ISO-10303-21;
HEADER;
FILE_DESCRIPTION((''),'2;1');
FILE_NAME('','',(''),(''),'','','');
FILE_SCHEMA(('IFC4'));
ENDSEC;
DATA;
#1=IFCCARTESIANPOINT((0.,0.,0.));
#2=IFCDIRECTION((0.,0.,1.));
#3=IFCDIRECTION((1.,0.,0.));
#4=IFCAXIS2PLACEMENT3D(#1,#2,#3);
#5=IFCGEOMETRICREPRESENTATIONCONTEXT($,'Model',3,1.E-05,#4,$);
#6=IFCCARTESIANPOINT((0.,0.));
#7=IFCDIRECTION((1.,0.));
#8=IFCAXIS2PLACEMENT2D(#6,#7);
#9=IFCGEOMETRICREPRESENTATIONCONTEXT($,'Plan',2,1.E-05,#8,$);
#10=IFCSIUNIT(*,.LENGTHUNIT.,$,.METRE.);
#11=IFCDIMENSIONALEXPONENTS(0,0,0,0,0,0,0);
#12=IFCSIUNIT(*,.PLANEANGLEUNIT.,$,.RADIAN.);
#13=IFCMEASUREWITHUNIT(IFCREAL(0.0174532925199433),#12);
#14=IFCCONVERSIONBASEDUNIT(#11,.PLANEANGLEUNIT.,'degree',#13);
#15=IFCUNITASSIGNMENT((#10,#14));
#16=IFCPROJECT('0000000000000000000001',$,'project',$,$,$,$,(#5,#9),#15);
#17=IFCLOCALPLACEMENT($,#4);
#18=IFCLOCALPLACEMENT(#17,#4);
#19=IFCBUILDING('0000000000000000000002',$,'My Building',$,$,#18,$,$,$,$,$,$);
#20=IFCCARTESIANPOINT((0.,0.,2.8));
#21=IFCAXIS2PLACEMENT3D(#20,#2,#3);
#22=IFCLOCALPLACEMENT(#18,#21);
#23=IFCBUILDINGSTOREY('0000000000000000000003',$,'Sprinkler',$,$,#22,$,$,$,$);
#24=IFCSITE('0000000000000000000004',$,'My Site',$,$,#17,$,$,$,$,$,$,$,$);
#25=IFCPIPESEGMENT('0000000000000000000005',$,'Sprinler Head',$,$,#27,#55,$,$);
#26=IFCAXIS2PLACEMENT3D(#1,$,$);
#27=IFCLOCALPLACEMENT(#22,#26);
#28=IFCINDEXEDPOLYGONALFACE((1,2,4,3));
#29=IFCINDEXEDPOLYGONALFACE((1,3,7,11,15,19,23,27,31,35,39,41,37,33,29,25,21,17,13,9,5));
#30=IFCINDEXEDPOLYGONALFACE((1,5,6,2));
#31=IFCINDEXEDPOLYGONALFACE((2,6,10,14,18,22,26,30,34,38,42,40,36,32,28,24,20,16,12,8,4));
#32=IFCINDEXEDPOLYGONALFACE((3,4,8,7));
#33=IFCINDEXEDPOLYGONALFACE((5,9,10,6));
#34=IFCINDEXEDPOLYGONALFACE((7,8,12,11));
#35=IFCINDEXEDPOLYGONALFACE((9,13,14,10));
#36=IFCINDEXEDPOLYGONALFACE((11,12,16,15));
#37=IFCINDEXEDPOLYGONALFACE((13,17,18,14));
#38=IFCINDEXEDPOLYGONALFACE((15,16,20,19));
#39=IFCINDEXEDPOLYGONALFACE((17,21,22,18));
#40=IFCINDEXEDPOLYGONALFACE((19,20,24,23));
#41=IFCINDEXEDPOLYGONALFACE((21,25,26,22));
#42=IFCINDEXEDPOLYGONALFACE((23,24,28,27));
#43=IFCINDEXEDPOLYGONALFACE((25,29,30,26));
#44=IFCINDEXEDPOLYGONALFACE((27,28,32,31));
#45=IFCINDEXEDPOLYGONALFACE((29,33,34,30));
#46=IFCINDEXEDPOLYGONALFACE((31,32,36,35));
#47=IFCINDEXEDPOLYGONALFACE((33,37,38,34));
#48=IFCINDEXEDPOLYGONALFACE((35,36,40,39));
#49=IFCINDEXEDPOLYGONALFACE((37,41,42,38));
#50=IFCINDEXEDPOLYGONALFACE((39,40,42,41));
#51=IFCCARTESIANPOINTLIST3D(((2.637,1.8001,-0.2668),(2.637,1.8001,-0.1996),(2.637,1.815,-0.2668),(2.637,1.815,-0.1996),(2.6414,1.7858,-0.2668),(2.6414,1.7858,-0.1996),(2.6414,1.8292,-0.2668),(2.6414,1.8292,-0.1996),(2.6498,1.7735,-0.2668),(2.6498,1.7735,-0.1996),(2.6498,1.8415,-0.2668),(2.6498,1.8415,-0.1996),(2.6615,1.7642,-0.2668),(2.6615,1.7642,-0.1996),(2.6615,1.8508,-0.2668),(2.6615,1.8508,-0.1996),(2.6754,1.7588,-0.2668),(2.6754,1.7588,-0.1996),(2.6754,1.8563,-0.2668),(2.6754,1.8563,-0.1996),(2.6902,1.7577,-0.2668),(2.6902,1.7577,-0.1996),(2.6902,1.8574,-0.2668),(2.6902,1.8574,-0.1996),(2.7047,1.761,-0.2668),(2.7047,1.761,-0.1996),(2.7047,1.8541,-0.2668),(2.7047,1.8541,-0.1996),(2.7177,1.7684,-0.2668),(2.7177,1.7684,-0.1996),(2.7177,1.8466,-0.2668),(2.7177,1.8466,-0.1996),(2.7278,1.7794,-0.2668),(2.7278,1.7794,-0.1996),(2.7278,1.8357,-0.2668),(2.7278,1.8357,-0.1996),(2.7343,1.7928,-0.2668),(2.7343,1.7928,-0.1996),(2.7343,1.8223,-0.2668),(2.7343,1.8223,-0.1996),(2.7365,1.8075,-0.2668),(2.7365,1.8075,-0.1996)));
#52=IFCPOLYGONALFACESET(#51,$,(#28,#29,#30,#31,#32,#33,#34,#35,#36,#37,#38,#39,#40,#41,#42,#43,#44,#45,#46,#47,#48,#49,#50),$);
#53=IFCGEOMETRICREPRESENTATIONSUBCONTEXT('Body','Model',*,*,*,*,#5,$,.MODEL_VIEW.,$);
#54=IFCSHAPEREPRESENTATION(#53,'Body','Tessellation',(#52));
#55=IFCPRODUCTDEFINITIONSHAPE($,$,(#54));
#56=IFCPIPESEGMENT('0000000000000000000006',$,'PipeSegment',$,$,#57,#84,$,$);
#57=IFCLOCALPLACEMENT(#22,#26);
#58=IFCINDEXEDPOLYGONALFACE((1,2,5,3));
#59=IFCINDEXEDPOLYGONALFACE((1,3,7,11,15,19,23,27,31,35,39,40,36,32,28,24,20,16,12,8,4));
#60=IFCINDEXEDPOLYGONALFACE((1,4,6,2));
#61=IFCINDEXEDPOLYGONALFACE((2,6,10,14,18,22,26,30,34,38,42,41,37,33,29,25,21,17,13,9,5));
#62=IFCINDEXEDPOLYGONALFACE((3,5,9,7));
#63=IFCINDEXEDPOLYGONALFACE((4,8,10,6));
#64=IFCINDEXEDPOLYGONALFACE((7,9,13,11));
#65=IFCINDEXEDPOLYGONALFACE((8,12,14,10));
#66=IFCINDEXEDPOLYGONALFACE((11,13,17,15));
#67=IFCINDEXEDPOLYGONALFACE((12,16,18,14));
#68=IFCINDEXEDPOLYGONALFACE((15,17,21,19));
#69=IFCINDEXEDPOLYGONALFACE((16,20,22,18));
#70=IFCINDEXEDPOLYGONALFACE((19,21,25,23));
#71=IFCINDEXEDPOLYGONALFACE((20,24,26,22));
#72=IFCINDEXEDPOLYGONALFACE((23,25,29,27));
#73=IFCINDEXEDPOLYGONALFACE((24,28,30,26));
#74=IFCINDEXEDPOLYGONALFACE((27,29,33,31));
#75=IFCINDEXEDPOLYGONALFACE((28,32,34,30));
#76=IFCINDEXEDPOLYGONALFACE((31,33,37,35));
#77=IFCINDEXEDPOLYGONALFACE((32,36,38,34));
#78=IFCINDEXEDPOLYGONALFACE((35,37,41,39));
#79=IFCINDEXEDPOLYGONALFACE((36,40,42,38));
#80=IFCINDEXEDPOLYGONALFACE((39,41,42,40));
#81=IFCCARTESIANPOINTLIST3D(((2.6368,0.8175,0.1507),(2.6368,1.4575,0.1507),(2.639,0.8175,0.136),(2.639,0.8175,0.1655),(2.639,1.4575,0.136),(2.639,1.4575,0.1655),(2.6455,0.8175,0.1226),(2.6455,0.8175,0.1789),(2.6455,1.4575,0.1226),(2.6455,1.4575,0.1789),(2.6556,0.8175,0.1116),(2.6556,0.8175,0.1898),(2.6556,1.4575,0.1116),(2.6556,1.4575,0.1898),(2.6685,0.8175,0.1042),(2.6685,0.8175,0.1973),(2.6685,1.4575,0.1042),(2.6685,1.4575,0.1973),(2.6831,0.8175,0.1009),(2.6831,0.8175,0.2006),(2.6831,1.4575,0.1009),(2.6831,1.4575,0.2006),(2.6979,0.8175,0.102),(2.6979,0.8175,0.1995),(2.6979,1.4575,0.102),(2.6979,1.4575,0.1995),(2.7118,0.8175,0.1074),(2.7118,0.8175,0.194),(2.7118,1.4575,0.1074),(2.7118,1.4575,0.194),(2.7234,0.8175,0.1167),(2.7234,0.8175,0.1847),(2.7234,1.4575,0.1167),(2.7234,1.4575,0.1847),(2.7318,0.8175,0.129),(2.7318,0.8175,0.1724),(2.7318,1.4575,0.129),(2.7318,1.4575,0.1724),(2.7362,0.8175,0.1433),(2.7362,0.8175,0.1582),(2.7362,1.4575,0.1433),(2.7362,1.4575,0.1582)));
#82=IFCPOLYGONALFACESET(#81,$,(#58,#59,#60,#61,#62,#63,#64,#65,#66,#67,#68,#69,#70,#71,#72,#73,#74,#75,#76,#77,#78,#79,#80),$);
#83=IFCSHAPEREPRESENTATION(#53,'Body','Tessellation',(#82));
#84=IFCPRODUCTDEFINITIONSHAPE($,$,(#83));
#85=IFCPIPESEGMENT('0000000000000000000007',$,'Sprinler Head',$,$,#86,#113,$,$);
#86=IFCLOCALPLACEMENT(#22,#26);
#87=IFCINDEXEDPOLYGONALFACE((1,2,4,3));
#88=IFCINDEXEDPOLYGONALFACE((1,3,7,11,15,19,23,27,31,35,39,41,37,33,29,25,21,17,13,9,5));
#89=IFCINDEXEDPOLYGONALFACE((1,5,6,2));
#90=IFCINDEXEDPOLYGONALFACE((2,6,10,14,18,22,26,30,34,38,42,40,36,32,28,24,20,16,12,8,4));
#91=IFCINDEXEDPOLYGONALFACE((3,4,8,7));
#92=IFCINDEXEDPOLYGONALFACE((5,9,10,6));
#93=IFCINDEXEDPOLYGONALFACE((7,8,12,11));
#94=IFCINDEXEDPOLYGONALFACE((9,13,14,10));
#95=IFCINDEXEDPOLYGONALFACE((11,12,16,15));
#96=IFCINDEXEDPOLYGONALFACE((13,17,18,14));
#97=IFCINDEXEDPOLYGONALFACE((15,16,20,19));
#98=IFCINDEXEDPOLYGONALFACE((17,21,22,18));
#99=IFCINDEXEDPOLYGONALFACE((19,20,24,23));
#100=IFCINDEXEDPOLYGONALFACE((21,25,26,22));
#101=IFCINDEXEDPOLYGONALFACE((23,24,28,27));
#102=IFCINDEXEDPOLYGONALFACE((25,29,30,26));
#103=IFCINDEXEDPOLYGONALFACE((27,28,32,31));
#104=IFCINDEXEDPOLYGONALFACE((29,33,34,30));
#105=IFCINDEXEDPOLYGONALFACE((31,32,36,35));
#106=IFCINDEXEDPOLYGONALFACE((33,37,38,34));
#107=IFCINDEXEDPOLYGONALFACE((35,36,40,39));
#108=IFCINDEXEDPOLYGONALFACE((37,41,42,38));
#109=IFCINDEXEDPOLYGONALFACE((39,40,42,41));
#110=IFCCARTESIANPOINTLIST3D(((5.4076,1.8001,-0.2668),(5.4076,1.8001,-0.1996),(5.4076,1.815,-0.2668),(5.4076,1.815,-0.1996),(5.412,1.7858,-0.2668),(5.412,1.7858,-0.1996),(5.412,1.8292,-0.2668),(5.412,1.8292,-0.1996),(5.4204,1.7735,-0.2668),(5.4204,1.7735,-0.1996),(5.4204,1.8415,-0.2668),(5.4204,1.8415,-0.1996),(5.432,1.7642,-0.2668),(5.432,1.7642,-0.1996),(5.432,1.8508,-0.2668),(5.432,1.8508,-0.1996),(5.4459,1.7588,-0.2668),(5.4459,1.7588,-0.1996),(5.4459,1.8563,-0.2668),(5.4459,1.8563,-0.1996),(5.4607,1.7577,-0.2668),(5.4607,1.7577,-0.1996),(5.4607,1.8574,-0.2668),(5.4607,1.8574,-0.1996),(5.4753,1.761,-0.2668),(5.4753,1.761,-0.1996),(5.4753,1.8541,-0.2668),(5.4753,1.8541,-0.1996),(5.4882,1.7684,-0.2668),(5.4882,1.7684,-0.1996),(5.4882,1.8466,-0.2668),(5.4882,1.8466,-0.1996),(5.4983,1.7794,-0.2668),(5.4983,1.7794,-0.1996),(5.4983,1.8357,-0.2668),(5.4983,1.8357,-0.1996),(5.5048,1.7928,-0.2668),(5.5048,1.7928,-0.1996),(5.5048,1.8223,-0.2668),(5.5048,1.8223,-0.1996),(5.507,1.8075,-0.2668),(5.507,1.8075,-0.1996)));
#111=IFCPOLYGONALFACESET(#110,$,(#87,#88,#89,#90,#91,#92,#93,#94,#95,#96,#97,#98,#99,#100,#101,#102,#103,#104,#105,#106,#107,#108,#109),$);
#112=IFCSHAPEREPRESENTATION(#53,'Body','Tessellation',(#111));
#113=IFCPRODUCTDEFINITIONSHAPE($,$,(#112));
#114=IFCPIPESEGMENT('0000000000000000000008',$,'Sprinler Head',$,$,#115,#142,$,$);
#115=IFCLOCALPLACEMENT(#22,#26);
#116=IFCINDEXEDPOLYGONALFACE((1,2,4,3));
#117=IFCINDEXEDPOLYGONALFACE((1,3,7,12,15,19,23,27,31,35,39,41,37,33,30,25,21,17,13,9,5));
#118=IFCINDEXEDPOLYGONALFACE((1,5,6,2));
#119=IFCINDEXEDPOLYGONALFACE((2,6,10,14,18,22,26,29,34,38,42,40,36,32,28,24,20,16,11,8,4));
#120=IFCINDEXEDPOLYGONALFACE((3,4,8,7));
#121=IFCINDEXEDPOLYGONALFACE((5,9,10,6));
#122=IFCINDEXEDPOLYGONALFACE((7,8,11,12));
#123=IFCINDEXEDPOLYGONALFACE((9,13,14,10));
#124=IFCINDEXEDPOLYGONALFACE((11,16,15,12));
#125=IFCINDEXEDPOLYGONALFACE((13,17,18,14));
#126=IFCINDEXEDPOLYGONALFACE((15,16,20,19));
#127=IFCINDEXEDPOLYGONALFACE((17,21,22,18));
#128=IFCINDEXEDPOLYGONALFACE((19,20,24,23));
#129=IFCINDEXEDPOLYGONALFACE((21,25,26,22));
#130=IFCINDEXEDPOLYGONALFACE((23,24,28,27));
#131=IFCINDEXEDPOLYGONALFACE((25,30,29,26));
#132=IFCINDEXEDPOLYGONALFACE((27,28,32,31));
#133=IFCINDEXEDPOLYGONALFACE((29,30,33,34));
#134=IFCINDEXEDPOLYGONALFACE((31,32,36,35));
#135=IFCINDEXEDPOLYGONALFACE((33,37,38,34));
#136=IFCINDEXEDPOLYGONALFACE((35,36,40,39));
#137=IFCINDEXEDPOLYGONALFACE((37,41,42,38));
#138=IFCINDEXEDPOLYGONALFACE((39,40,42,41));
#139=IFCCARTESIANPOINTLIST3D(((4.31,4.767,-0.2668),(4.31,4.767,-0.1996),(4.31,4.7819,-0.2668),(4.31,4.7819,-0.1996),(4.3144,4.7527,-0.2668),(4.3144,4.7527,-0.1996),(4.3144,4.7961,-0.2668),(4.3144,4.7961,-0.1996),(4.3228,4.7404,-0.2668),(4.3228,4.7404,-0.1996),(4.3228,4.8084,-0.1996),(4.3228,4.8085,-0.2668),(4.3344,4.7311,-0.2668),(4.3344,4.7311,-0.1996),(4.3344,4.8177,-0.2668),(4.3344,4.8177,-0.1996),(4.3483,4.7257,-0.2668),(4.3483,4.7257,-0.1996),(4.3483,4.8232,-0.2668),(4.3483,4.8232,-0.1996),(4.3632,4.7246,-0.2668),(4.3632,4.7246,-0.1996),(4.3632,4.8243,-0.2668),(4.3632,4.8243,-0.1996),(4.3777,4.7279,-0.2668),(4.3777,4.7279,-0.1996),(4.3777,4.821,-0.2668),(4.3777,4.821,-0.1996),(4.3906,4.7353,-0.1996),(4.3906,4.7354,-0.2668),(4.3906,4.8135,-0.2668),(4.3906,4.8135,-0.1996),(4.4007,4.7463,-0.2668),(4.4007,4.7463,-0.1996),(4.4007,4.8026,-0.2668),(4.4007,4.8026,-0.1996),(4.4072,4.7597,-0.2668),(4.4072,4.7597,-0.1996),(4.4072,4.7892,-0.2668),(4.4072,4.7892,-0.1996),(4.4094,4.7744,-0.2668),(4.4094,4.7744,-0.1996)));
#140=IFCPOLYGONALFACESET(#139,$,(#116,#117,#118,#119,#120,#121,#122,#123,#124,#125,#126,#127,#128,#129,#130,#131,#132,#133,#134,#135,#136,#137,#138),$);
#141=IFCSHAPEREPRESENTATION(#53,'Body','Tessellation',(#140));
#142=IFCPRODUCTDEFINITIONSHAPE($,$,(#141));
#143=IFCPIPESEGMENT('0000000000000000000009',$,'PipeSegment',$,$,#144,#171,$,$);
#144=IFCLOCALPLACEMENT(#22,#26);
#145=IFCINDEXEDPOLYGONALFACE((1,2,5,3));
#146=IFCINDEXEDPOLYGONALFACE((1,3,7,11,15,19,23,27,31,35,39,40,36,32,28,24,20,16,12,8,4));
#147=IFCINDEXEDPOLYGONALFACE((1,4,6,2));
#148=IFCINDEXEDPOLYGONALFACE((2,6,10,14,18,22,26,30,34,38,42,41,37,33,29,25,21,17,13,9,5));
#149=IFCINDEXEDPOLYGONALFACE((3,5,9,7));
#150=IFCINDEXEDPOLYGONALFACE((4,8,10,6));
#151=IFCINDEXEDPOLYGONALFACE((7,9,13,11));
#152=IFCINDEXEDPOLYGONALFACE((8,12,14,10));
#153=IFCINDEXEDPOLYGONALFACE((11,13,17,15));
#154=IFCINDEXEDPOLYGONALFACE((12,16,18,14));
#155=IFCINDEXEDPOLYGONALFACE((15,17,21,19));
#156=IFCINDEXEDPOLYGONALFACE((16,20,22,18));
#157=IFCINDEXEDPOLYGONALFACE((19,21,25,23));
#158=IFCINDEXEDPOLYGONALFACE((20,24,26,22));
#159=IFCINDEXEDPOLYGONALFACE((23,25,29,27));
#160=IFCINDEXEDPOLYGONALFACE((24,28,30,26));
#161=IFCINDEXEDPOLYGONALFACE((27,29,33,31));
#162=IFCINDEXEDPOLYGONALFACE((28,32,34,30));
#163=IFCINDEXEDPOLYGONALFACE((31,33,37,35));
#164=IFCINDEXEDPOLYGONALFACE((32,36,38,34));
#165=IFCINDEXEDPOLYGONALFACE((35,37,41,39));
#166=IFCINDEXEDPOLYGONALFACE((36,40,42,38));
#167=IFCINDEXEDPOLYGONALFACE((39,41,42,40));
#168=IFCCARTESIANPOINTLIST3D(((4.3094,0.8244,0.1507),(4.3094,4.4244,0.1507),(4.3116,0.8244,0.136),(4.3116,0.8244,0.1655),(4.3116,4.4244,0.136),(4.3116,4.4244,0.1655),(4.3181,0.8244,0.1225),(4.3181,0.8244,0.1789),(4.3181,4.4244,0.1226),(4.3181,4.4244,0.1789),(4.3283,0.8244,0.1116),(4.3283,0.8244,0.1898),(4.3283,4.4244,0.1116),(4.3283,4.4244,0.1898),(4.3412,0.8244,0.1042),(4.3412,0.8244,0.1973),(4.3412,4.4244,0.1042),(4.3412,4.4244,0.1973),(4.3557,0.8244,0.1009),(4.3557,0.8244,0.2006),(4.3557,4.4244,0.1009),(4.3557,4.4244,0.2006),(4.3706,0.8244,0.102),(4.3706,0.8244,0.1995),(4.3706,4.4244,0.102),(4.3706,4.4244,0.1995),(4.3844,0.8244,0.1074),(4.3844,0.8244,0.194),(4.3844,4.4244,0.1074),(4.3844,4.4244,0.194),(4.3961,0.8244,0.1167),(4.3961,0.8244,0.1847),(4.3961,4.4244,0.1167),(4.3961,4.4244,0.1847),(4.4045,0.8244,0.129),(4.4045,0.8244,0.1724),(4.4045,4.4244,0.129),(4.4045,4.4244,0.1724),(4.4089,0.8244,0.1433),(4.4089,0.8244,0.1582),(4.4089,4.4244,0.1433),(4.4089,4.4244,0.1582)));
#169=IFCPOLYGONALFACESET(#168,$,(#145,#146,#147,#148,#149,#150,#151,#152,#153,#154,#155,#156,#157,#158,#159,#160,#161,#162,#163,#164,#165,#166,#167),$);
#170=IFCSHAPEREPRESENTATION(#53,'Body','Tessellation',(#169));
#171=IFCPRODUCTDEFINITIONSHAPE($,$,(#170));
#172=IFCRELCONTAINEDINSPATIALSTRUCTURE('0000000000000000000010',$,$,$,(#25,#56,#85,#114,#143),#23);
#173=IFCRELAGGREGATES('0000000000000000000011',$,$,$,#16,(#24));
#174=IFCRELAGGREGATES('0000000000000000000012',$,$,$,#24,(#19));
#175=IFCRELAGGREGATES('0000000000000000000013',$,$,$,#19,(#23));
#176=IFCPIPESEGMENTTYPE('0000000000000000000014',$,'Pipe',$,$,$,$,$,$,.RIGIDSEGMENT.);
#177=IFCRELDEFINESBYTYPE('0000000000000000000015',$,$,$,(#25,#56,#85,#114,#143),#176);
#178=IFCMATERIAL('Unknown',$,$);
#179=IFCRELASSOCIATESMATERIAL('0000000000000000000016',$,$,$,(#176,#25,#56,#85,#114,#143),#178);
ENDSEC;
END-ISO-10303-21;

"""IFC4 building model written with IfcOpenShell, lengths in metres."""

from ifc_helpers import new_model, entity, si_unit, converted_unit, frame, origin_with_axes, origin_2d_with_axis, place, context, subcontext, project, spatial, circle, extrude, material, material_profile, profile_set, profile_usage, type_object, element, save


model = new_model("IFC4")

# Units and contexts
model_context = context("Model", 3, precision=1e-05, world=origin_with_axes())
plan_context = context("Plan", 2, precision=1e-05, world=origin_2d_with_axis())
body_context = subcontext(model_context, "Body", "Model", "MODEL_VIEW")
ifc_project = project(units=[si_unit("LENGTHUNIT", "METRE"), converted_unit("PLANEANGLEUNIT", "degree", entity("IfcReal", 0.0174532925199433), si_unit("PLANEANGLEUNIT", "RADIAN"), dimensions=[0, 0, 0, 0, 0, 0, 0])], contexts=[model_context, plan_context])

# Site, building, storey
site_placement = place(None, origin_with_axes())
site = spatial("IfcSite", under=ifc_project, at=site_placement, Name="My Site")
building_placement = place(site_placement, origin_with_axes())
building = spatial("IfcBuilding", under=site, at=building_placement, Name="My Building")
storey_placement = place(building_placement, frame((0.0, 0.0, 2.8), z_axis=(0.0, 0.0, 1.0), x_axis=(1.0, 0.0, 0.0)))
storey = spatial("IfcBuildingStorey", under=building, at=storey_placement, Name="Sprinkler")

# Pipe segments
ifc_material = material(Name="Unknown")
ifc_material_profile_1 = material_profile(ifc_material, circle(Radius=0.05))
ifc_profile_set_1 = profile_set([ifc_material_profile_1])
pipe_segment_type = type_object("IfcPipeSegmentType", Name="Pipe", PredefinedType="RIGIDSEGMENT", material=ifc_profile_set_1)
ifc_profile_usage_1 = profile_usage(ifc_profile_set_1, cardinal=5)
pipe_segment_1_placement = place(storey_placement, frame((2.6865, 1.8075, -0.2668), z_axis=(0.0, -0.000008, 1.0), x_axis=(1.0, 0.0, 0.0)))
element("IfcPipeSegment", 1, at=pipe_segment_1_placement, inside=storey, type_object=pipe_segment_type, material=ifc_profile_usage_1, Name="Sprinler Head", context=body_context, shape_type="SweptSolid", body=[
    extrude(circle(Radius=0.05), origin_with_axes(), (0.0, 0.0, 1.0), 0.0672),
])
ifc_profile_usage_2 = profile_usage(ifc_profile_set_1, cardinal=5)
pipe_segment_2_placement = place(storey_placement, frame((2.6868, 0.8175, 0.1507), z_axis=(0.0, 1.0, 0.0), x_axis=(-1.0, 0.0, 0.0)))
element("IfcPipeSegment", 2, at=pipe_segment_2_placement, inside=storey, type_object=pipe_segment_type, material=ifc_profile_usage_2, Name="PipeSegment", context=body_context, shape_type="SweptSolid", body=[
    extrude(circle(Radius=0.05), origin_with_axes(), (0.0, 0.0, 1.0), 0.64),
])
ifc_profile_usage_3 = profile_usage(ifc_profile_set_1, cardinal=5)
pipe_segment_3_placement = place(storey_placement, frame((5.457, 1.8075, -0.2668), z_axis=(0.0, -0.000008, 1.0), x_axis=(1.0, 0.0, 0.0)))
element("IfcPipeSegment", 3, at=pipe_segment_3_placement, inside=storey, type_object=pipe_segment_type, material=ifc_profile_usage_3, Name="Sprinler Head", context=body_context, shape_type="SweptSolid", body=[
    extrude(circle(Radius=0.05), origin_with_axes(), (0.0, 0.0, 1.0), 0.0672),
])
ifc_profile_usage_4 = profile_usage(ifc_profile_set_1, cardinal=5)
pipe_segment_4_placement = place(storey_placement, frame((4.3594, 4.7744, -0.2668), z_axis=(0.0, -0.000008, 1.0), x_axis=(1.0, 0.0, 0.0)))
element("IfcPipeSegment", 4, at=pipe_segment_4_placement, inside=storey, type_object=pipe_segment_type, material=ifc_profile_usage_4, Name="Sprinler Head", context=body_context, shape_type="SweptSolid", body=[
    extrude(circle(Radius=0.05), origin_with_axes(), (0.0, 0.0, 1.0), 0.0672),
])
ifc_profile_usage_5 = profile_usage(ifc_profile_set_1, cardinal=5)
pipe_segment_5_placement = place(storey_placement, frame((4.3594, 0.8244, 0.1507), z_axis=(0.0, 1.0, 0.000004), x_axis=(-1.0, 0.0, 0.0)))
element("IfcPipeSegment", 5, at=pipe_segment_5_placement, inside=storey, type_object=pipe_segment_type, material=ifc_profile_usage_5, Name="PipeSegment", context=body_context, shape_type="SweptSolid", body=[
    extrude(circle(Radius=0.05), origin_with_axes(), (0.0, 0.0, 1.0), 3.6),
])

save(model, "model.ifc")
